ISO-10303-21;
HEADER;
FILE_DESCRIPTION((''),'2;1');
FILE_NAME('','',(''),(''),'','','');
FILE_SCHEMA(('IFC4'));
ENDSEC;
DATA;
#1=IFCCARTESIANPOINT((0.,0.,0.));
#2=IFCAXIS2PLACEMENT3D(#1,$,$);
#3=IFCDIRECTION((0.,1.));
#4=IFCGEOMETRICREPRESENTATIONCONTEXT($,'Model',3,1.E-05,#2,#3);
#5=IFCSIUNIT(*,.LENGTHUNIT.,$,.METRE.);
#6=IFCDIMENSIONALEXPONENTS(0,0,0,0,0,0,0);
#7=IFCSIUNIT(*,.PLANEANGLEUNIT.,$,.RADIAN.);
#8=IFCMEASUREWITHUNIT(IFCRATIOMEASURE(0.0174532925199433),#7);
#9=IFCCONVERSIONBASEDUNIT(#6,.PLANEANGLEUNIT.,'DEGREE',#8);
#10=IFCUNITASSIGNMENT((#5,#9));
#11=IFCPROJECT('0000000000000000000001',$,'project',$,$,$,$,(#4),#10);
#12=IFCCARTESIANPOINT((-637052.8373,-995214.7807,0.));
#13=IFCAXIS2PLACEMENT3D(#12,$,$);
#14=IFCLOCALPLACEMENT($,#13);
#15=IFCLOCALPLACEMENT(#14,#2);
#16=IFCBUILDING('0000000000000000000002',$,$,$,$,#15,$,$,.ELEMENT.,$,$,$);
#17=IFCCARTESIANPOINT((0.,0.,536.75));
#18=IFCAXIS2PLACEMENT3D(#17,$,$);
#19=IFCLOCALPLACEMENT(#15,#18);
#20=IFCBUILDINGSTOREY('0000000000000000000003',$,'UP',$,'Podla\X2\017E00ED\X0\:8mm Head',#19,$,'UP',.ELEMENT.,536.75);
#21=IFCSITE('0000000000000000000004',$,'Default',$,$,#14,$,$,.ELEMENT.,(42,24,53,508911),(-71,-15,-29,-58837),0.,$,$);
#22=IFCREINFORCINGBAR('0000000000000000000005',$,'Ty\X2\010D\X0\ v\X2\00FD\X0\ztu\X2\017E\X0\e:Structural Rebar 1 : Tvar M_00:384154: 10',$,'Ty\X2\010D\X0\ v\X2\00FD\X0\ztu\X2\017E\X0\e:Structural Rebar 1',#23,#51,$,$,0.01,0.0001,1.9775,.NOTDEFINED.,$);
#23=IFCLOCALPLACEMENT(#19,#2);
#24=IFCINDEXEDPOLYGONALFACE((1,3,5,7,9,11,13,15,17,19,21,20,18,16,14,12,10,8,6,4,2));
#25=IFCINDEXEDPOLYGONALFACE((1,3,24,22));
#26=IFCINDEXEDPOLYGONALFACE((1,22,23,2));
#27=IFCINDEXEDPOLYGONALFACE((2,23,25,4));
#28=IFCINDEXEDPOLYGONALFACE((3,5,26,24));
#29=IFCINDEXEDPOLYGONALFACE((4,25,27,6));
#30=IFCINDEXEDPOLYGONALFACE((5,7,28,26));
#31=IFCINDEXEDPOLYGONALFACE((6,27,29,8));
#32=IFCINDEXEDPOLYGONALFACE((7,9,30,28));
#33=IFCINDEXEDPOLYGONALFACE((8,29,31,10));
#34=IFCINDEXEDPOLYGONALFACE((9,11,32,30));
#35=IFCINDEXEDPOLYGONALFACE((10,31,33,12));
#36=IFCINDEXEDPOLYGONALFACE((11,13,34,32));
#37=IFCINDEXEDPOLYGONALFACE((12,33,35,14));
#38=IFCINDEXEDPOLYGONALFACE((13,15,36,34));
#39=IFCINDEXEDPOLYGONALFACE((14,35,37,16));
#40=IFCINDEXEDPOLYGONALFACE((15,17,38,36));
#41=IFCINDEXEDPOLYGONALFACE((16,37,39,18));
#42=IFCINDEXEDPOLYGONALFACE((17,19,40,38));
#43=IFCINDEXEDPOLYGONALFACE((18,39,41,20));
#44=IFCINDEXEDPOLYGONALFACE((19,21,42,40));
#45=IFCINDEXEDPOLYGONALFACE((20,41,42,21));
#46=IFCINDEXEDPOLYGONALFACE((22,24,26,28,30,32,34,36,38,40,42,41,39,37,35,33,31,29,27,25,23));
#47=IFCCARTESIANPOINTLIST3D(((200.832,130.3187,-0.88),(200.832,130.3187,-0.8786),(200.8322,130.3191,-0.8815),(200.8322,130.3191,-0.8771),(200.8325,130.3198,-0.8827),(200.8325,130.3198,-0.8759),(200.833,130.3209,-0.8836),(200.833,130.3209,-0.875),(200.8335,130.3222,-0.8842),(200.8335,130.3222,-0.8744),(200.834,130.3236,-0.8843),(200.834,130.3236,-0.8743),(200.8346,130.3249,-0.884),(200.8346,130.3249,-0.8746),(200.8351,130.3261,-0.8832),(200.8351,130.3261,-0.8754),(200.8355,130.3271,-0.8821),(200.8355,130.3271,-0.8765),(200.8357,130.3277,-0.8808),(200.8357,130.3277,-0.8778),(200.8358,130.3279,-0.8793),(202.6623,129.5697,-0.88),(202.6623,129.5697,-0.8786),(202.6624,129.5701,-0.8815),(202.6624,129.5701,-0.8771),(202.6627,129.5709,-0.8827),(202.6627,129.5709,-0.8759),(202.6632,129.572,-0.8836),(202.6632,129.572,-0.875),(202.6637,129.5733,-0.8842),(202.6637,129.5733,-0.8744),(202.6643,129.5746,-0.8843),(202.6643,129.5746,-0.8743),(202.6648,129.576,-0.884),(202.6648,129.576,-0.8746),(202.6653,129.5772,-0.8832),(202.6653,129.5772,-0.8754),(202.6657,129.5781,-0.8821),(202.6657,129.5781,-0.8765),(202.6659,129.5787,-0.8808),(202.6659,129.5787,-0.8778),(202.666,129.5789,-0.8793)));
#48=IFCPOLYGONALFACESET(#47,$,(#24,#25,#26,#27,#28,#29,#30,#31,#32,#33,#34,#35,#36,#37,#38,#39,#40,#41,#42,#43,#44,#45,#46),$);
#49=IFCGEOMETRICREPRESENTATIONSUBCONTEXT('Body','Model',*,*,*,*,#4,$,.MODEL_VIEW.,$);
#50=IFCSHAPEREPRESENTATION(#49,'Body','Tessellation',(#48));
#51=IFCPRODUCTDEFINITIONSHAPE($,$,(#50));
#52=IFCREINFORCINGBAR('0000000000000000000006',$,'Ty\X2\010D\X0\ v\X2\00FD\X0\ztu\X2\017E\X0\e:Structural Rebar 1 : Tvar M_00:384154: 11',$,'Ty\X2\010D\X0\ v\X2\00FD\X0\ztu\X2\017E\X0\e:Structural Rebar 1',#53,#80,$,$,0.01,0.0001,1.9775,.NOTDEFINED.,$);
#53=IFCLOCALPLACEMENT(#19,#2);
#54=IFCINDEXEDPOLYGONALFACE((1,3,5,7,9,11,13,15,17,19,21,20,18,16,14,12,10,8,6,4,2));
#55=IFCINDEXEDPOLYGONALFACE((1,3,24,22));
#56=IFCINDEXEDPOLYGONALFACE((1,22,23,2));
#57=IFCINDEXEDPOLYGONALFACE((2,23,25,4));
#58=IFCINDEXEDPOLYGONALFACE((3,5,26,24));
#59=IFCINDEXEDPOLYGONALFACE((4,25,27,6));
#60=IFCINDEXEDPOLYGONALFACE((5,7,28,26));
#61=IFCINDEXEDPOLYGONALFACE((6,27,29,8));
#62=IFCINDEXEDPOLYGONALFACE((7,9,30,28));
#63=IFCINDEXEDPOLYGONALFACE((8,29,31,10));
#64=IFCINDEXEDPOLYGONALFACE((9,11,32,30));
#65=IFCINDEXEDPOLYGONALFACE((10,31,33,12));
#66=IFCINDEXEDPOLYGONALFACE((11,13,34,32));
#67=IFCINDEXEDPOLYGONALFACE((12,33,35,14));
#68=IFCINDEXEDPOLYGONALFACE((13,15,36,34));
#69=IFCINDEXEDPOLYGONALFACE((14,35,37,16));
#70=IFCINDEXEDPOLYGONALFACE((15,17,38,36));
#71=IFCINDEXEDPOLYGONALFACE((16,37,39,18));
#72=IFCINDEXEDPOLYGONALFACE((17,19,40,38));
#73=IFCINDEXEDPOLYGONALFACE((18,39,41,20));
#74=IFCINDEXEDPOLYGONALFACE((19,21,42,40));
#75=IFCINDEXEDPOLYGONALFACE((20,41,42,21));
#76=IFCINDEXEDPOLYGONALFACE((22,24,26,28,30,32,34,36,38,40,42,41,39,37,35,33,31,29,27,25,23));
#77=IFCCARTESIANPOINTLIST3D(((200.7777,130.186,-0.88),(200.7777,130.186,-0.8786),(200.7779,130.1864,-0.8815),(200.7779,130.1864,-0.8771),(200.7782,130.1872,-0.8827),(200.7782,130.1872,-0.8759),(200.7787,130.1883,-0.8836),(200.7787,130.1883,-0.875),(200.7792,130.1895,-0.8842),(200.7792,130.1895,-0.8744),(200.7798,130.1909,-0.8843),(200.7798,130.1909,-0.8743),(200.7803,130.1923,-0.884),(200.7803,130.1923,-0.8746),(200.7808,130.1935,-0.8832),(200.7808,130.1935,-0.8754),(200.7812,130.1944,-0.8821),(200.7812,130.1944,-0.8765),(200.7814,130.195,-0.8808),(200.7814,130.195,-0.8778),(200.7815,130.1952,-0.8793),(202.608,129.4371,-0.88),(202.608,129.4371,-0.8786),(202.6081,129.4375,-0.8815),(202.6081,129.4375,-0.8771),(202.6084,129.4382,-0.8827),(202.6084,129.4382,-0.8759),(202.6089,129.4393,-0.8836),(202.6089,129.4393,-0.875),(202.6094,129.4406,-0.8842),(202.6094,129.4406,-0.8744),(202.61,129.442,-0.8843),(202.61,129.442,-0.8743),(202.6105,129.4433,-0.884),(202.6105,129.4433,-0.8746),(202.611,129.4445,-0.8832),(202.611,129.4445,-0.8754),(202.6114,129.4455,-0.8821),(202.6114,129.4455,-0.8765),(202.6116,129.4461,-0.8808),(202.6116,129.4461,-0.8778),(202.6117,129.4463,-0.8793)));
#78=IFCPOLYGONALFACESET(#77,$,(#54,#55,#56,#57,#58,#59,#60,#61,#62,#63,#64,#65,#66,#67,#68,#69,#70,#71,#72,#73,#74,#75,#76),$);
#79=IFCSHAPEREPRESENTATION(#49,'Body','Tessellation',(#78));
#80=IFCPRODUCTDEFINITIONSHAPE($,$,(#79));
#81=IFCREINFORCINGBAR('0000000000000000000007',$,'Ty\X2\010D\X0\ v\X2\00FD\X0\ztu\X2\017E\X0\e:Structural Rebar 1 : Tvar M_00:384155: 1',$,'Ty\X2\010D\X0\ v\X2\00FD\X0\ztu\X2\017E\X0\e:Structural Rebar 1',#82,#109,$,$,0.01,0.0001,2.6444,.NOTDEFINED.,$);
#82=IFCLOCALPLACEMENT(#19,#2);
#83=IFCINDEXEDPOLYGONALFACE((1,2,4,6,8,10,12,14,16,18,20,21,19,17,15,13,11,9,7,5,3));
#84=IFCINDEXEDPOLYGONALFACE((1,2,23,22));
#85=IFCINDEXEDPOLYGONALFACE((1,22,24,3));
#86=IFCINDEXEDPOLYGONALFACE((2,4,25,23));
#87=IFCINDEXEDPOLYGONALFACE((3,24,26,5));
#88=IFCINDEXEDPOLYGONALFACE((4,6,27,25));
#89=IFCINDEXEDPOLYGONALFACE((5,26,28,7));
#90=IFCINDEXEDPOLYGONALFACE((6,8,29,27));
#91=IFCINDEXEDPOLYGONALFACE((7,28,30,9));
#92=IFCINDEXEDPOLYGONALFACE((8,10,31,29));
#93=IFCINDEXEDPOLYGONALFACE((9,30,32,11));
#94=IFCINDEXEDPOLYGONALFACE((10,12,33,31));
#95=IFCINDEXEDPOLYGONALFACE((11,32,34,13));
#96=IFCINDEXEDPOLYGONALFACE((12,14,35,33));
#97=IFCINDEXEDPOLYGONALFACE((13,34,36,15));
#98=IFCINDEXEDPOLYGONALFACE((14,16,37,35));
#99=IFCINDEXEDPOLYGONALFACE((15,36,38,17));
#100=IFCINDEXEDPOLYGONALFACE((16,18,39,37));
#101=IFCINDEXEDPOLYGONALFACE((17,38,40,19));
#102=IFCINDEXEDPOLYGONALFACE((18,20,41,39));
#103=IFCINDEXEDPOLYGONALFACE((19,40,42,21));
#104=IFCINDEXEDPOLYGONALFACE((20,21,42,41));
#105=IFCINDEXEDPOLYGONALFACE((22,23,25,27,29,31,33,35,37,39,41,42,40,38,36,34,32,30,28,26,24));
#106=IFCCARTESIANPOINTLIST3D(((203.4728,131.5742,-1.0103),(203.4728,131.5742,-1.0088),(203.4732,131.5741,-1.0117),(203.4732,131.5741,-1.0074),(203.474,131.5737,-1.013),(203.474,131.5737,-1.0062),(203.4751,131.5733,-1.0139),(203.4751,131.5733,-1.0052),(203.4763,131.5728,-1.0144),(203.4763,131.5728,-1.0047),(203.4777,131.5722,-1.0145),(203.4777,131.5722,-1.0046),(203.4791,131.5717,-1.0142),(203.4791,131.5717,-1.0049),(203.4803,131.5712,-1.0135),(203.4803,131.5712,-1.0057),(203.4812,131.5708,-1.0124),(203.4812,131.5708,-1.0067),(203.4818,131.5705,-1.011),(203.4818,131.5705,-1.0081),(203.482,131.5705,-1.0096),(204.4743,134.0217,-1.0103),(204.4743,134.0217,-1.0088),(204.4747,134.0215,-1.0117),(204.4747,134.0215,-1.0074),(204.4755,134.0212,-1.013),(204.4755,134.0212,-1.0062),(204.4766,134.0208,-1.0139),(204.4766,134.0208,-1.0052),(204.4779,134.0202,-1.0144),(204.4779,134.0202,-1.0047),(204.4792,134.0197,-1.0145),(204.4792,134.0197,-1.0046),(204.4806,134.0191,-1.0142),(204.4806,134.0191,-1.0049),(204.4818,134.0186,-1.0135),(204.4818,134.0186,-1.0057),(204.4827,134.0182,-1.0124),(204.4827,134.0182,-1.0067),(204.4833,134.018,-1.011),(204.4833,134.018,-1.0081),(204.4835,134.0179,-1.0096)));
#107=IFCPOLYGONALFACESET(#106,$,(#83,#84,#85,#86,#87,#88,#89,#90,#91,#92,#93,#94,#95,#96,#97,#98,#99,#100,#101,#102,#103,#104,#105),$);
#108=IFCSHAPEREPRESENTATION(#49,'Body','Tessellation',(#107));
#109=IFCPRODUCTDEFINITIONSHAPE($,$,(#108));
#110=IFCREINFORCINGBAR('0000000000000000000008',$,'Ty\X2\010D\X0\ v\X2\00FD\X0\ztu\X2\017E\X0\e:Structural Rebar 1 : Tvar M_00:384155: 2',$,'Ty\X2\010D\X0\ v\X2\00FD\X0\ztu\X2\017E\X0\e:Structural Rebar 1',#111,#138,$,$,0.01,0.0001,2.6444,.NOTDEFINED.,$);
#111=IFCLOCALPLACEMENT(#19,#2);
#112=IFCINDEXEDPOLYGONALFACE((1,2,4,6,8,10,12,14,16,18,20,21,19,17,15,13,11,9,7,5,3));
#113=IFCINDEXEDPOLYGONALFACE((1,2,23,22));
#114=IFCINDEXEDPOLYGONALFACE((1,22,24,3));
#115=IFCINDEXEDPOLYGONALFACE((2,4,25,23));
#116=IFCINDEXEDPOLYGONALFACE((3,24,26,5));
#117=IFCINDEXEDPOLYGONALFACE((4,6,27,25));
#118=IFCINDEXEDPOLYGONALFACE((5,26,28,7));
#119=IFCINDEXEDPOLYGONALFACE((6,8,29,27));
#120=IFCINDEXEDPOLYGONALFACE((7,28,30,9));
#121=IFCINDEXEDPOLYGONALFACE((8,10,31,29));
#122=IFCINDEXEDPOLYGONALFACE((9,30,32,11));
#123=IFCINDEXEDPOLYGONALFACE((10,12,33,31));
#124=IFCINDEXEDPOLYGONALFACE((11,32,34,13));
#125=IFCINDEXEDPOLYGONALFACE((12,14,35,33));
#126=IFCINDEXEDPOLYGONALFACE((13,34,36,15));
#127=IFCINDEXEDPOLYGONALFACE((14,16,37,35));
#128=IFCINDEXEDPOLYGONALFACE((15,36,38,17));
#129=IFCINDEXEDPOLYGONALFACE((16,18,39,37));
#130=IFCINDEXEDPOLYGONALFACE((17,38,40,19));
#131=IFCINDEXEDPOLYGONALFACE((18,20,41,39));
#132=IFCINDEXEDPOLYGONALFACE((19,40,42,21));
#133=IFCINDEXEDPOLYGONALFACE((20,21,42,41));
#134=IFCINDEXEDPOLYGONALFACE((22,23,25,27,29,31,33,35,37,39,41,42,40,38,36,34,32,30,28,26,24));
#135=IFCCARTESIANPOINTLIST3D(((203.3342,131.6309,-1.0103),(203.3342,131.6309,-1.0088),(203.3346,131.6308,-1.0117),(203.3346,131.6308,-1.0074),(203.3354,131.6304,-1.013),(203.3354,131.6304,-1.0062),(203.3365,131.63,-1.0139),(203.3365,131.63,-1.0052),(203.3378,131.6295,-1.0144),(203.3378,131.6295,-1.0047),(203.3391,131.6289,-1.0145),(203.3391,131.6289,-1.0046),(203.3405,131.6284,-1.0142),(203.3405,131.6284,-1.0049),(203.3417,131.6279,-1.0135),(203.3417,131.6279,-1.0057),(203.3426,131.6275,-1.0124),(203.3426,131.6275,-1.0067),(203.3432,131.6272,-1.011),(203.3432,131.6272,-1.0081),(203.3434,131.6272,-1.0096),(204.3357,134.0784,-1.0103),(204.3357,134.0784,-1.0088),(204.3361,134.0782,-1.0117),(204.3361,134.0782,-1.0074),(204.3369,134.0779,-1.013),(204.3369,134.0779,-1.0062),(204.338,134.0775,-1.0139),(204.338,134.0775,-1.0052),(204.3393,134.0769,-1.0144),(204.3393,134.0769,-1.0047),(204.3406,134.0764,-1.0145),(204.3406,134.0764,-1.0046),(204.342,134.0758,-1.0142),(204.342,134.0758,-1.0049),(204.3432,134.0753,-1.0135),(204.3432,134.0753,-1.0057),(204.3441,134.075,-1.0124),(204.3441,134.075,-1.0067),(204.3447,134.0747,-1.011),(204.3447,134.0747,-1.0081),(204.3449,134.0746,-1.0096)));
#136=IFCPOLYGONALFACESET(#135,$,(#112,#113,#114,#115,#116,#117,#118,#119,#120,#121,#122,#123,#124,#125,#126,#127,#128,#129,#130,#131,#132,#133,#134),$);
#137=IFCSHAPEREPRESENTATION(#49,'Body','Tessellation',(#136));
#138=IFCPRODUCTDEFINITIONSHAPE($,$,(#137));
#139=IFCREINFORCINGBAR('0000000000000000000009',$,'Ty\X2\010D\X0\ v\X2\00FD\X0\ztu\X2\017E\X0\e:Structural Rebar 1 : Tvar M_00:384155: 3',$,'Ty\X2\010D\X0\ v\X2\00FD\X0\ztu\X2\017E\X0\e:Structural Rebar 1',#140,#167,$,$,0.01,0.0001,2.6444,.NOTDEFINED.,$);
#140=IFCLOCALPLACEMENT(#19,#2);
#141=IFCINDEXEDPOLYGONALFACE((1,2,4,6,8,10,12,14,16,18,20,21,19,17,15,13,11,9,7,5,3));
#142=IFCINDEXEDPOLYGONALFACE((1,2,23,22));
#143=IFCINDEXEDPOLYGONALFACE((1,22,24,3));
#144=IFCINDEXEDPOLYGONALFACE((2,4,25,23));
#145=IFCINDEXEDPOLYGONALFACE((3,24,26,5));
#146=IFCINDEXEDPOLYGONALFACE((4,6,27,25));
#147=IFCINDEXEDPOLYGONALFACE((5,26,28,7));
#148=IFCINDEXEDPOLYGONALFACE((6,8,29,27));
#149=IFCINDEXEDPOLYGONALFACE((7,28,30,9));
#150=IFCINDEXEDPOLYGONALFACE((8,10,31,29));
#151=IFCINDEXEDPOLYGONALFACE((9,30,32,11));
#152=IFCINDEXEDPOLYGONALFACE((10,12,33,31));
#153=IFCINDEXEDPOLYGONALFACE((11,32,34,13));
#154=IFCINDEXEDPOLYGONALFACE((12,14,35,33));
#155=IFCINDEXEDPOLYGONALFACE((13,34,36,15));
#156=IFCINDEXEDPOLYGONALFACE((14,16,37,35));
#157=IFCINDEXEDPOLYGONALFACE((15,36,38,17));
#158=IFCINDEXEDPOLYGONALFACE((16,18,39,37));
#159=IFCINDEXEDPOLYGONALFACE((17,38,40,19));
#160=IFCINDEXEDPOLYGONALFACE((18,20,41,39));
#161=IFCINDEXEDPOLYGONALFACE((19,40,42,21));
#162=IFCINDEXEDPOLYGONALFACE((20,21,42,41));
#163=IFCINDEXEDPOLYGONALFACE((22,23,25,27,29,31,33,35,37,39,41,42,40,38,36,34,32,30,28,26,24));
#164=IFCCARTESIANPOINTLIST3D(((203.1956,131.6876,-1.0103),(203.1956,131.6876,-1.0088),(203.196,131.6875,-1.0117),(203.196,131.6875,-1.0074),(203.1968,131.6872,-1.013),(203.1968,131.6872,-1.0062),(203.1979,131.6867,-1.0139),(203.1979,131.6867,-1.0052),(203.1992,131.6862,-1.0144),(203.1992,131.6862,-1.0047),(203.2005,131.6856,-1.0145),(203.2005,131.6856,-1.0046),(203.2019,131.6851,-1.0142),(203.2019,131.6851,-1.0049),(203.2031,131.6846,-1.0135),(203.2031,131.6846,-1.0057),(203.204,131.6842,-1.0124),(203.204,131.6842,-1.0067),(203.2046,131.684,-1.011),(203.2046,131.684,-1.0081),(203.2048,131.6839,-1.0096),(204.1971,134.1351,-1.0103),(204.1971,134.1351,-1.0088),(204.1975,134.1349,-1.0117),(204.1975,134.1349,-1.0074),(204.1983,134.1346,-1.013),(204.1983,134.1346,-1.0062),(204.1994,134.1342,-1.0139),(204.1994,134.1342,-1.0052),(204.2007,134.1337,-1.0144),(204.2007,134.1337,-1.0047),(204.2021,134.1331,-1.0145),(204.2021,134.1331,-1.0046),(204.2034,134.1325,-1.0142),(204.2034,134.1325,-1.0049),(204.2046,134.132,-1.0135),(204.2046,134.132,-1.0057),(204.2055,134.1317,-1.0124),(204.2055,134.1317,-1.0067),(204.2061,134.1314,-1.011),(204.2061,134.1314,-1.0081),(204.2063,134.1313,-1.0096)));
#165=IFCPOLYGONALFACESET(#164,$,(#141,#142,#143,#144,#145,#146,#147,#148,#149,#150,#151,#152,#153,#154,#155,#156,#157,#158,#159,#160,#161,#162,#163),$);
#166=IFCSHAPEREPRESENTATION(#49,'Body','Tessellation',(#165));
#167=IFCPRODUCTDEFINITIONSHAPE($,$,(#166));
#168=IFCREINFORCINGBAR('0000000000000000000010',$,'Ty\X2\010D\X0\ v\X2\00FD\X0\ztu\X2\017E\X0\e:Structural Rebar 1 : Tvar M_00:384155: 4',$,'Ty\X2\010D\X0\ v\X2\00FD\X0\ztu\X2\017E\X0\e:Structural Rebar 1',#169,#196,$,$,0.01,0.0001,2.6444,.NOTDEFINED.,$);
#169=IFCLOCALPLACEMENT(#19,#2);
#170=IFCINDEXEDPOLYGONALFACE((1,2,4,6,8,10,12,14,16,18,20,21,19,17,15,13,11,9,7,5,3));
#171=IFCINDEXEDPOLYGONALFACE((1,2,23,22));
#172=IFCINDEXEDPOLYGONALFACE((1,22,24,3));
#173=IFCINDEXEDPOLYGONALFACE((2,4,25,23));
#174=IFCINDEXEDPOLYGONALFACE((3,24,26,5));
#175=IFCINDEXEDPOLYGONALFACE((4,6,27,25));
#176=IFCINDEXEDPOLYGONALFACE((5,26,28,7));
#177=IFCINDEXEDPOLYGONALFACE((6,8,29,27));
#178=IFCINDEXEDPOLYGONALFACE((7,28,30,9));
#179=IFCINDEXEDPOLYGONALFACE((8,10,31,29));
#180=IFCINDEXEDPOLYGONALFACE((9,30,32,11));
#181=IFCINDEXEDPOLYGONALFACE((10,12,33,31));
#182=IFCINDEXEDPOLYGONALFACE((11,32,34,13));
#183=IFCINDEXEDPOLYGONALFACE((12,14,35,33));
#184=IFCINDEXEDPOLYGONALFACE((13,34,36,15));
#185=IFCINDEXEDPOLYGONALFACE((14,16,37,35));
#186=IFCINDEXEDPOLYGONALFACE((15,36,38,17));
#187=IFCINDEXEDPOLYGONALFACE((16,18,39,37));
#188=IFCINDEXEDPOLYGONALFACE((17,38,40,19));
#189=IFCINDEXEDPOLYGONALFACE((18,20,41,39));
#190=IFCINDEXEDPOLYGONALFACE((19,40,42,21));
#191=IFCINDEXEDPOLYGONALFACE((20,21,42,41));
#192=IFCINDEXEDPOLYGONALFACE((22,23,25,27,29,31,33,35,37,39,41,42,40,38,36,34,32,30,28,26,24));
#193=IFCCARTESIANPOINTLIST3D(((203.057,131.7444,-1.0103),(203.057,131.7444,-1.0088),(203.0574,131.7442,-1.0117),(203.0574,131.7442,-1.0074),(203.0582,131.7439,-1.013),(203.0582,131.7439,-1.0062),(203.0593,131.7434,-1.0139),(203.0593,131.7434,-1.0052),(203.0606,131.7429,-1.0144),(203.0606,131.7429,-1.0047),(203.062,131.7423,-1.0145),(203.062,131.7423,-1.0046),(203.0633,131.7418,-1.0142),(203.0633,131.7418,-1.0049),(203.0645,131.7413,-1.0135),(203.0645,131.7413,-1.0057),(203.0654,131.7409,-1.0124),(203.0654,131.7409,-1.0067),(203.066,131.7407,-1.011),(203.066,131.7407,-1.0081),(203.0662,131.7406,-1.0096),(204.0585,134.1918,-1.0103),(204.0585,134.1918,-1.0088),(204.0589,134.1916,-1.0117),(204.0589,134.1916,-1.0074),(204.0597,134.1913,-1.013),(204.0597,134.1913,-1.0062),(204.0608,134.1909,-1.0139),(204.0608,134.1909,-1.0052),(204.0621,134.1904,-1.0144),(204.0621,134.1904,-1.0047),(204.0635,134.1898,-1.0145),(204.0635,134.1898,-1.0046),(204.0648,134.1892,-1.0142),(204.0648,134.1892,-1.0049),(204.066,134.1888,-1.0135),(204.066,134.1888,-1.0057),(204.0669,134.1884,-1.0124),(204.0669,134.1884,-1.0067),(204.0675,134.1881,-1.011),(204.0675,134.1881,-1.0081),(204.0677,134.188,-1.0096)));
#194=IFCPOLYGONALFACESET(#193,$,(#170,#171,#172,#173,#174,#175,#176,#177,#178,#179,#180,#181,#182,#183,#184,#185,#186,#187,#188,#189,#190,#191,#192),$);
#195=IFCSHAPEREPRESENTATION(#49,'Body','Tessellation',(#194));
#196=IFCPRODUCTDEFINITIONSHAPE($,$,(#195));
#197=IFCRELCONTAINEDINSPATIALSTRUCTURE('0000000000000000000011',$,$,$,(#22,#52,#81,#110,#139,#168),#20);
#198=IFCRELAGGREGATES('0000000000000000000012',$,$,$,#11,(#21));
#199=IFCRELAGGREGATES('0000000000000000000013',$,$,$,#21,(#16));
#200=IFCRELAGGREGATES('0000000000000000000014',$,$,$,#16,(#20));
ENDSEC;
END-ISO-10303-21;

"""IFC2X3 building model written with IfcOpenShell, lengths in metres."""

from ifc_helpers import new_model, entity, si_unit, converted_unit, direction, frame, origin, place, context, subcontext, project, spatial, element, save


model = new_model("IFC2X3")

# Units and contexts
model_context = context("Model", 3, precision=1e-05, world=origin(), true_north=direction((0.0, 1.0)))
body_context = subcontext(model_context, "Body", "Model", "MODEL_VIEW")
ifc_project = project(units=[si_unit("LENGTHUNIT", "METRE"), converted_unit("PLANEANGLEUNIT", "DEGREE", entity("IfcRatioMeasure", 0.0174532925199433), si_unit("PLANEANGLEUNIT", "RADIAN"), dimensions=[0, 0, 0, 0, 0, 0, 0])], contexts=[model_context])

# Site, building, storey
site_placement = place(None, frame((-637052.8373, -995214.7807, 0.0)))
site = spatial("IfcSite", under=ifc_project, at=site_placement, Name="Default", CompositionType="ELEMENT", RefLatitude=(42, 24, 53, 508911), RefLongitude=(-71, -15, -29, -58837), RefElevation=0.0)
building_placement = place(site_placement, origin())
building = spatial("IfcBuilding", under=site, at=building_placement, CompositionType="ELEMENT")
storey_placement = place(building_placement, frame((0.0, 0.0, 536.75)))
storey = spatial("IfcBuildingStorey", under=building, at=storey_placement, Name="UP", ObjectType="Podlaží:8mm Head", LongName="UP", CompositionType="ELEMENT", Elevation=536.75)

# Reinforcing bars
reinforcing_bar_1_placement = place(storey_placement, origin())
element("IfcReinforcingBar", 1, at=reinforcing_bar_1_placement, inside=storey, Name="Tyč výztuže:Structural Rebar 1 : Tvar M_00:384154: 10", ObjectType="Tyč výztuže:Structural Rebar 1", BarLength=1.9775, BarRole="NOTDEFINED", CrossSectionArea=0.0001, NominalDiameter=0.01, context=body_context, shape_type="AdvancedSweptSolid", body=[
    entity("IfcSweptDiskSolid", entity("IfcCompositeCurve", [entity("IfcCompositeCurveSegment", "CONTINUOUS", True, entity("IfcPolyline", [entity("IfcCartesianPoint", [-202.6641, -129.5743, 0.8793]), entity("IfcCartesianPoint", [-200.8339, -130.3232, 0.8793])]))], False), 0.005, None, 0.0, 1.0),
])
reinforcing_bar_2_placement = place(storey_placement, origin())
element("IfcReinforcingBar", 2, at=reinforcing_bar_2_placement, inside=storey, Name="Tyč výztuže:Structural Rebar 1 : Tvar M_00:384154: 11", ObjectType="Tyč výztuže:Structural Rebar 1", BarLength=1.9775, BarRole="NOTDEFINED", CrossSectionArea=0.0001, NominalDiameter=0.01, context=body_context, shape_type="AdvancedSweptSolid", body=[
    entity("IfcSweptDiskSolid", entity("IfcCompositeCurve", [entity("IfcCompositeCurveSegment", "CONTINUOUS", True, entity("IfcPolyline", [entity("IfcCartesianPoint", [-202.6098, -129.4416, 0.8793]), entity("IfcCartesianPoint", [-200.7796, -130.1906, 0.8793])]))], False), 0.005, None, 0.0, 1.0),
])
reinforcing_bar_3_placement = place(storey_placement, origin())
element("IfcReinforcingBar", 3, at=reinforcing_bar_3_placement, inside=storey, Name="Tyč výztuže:Structural Rebar 1 : Tvar M_00:384155: 1", ObjectType="Tyč výztuže:Structural Rebar 1", BarLength=2.6444, BarRole="NOTDEFINED", CrossSectionArea=0.0001, NominalDiameter=0.01, context=body_context, shape_type="AdvancedSweptSolid", body=[
    entity("IfcSweptDiskSolid", entity("IfcCompositeCurve", [entity("IfcCompositeCurveSegment", "CONTINUOUS", True, entity("IfcPolyline", [entity("IfcCartesianPoint", [-204.4789, -134.0198, 1.0096]), entity("IfcCartesianPoint", [-203.4774, -131.5723, 1.0096])]))], False), 0.005, None, 0.0, 1.0),
])
reinforcing_bar_4_placement = place(storey_placement, origin())
element("IfcReinforcingBar", 4, at=reinforcing_bar_4_placement, inside=storey, Name="Tyč výztuže:Structural Rebar 1 : Tvar M_00:384155: 2", ObjectType="Tyč výztuže:Structural Rebar 1", BarLength=2.6444, BarRole="NOTDEFINED", CrossSectionArea=0.0001, NominalDiameter=0.01, context=body_context, shape_type="AdvancedSweptSolid", body=[
    entity("IfcSweptDiskSolid", entity("IfcCompositeCurve", [entity("IfcCompositeCurveSegment", "CONTINUOUS", True, entity("IfcPolyline", [entity("IfcCartesianPoint", [-204.3403, -134.0765, 1.0096]), entity("IfcCartesianPoint", [-203.3388, -131.6291, 1.0096])]))], False), 0.005, None, 0.0, 1.0),
])
reinforcing_bar_5_placement = place(storey_placement, origin())
element("IfcReinforcingBar", 5, at=reinforcing_bar_5_placement, inside=storey, Name="Tyč výztuže:Structural Rebar 1 : Tvar M_00:384155: 3", ObjectType="Tyč výztuže:Structural Rebar 1", BarLength=2.6444, BarRole="NOTDEFINED", CrossSectionArea=0.0001, NominalDiameter=0.01, context=body_context, shape_type="AdvancedSweptSolid", body=[
    entity("IfcSweptDiskSolid", entity("IfcCompositeCurve", [entity("IfcCompositeCurveSegment", "CONTINUOUS", True, entity("IfcPolyline", [entity("IfcCartesianPoint", [-204.2017, -134.1332, 1.0096]), entity("IfcCartesianPoint", [-203.2002, -131.6858, 1.0096])]))], False), 0.005, None, 0.0, 1.0),
])
reinforcing_bar_6_placement = place(storey_placement, origin())
element("IfcReinforcingBar", 6, at=reinforcing_bar_6_placement, inside=storey, Name="Tyč výztuže:Structural Rebar 1 : Tvar M_00:384155: 4", ObjectType="Tyč výztuže:Structural Rebar 1", BarLength=2.6444, BarRole="NOTDEFINED", CrossSectionArea=0.0001, NominalDiameter=0.01, context=body_context, shape_type="AdvancedSweptSolid", body=[
    entity("IfcSweptDiskSolid", entity("IfcCompositeCurve", [entity("IfcCompositeCurveSegment", "CONTINUOUS", True, entity("IfcPolyline", [entity("IfcCartesianPoint", [-204.0631, -134.1899, 1.0096]), entity("IfcCartesianPoint", [-203.0616, -131.7425, 1.0096])]))], False), 0.005, None, 0.0, 1.0),
])

save(model, "model.ifc")
